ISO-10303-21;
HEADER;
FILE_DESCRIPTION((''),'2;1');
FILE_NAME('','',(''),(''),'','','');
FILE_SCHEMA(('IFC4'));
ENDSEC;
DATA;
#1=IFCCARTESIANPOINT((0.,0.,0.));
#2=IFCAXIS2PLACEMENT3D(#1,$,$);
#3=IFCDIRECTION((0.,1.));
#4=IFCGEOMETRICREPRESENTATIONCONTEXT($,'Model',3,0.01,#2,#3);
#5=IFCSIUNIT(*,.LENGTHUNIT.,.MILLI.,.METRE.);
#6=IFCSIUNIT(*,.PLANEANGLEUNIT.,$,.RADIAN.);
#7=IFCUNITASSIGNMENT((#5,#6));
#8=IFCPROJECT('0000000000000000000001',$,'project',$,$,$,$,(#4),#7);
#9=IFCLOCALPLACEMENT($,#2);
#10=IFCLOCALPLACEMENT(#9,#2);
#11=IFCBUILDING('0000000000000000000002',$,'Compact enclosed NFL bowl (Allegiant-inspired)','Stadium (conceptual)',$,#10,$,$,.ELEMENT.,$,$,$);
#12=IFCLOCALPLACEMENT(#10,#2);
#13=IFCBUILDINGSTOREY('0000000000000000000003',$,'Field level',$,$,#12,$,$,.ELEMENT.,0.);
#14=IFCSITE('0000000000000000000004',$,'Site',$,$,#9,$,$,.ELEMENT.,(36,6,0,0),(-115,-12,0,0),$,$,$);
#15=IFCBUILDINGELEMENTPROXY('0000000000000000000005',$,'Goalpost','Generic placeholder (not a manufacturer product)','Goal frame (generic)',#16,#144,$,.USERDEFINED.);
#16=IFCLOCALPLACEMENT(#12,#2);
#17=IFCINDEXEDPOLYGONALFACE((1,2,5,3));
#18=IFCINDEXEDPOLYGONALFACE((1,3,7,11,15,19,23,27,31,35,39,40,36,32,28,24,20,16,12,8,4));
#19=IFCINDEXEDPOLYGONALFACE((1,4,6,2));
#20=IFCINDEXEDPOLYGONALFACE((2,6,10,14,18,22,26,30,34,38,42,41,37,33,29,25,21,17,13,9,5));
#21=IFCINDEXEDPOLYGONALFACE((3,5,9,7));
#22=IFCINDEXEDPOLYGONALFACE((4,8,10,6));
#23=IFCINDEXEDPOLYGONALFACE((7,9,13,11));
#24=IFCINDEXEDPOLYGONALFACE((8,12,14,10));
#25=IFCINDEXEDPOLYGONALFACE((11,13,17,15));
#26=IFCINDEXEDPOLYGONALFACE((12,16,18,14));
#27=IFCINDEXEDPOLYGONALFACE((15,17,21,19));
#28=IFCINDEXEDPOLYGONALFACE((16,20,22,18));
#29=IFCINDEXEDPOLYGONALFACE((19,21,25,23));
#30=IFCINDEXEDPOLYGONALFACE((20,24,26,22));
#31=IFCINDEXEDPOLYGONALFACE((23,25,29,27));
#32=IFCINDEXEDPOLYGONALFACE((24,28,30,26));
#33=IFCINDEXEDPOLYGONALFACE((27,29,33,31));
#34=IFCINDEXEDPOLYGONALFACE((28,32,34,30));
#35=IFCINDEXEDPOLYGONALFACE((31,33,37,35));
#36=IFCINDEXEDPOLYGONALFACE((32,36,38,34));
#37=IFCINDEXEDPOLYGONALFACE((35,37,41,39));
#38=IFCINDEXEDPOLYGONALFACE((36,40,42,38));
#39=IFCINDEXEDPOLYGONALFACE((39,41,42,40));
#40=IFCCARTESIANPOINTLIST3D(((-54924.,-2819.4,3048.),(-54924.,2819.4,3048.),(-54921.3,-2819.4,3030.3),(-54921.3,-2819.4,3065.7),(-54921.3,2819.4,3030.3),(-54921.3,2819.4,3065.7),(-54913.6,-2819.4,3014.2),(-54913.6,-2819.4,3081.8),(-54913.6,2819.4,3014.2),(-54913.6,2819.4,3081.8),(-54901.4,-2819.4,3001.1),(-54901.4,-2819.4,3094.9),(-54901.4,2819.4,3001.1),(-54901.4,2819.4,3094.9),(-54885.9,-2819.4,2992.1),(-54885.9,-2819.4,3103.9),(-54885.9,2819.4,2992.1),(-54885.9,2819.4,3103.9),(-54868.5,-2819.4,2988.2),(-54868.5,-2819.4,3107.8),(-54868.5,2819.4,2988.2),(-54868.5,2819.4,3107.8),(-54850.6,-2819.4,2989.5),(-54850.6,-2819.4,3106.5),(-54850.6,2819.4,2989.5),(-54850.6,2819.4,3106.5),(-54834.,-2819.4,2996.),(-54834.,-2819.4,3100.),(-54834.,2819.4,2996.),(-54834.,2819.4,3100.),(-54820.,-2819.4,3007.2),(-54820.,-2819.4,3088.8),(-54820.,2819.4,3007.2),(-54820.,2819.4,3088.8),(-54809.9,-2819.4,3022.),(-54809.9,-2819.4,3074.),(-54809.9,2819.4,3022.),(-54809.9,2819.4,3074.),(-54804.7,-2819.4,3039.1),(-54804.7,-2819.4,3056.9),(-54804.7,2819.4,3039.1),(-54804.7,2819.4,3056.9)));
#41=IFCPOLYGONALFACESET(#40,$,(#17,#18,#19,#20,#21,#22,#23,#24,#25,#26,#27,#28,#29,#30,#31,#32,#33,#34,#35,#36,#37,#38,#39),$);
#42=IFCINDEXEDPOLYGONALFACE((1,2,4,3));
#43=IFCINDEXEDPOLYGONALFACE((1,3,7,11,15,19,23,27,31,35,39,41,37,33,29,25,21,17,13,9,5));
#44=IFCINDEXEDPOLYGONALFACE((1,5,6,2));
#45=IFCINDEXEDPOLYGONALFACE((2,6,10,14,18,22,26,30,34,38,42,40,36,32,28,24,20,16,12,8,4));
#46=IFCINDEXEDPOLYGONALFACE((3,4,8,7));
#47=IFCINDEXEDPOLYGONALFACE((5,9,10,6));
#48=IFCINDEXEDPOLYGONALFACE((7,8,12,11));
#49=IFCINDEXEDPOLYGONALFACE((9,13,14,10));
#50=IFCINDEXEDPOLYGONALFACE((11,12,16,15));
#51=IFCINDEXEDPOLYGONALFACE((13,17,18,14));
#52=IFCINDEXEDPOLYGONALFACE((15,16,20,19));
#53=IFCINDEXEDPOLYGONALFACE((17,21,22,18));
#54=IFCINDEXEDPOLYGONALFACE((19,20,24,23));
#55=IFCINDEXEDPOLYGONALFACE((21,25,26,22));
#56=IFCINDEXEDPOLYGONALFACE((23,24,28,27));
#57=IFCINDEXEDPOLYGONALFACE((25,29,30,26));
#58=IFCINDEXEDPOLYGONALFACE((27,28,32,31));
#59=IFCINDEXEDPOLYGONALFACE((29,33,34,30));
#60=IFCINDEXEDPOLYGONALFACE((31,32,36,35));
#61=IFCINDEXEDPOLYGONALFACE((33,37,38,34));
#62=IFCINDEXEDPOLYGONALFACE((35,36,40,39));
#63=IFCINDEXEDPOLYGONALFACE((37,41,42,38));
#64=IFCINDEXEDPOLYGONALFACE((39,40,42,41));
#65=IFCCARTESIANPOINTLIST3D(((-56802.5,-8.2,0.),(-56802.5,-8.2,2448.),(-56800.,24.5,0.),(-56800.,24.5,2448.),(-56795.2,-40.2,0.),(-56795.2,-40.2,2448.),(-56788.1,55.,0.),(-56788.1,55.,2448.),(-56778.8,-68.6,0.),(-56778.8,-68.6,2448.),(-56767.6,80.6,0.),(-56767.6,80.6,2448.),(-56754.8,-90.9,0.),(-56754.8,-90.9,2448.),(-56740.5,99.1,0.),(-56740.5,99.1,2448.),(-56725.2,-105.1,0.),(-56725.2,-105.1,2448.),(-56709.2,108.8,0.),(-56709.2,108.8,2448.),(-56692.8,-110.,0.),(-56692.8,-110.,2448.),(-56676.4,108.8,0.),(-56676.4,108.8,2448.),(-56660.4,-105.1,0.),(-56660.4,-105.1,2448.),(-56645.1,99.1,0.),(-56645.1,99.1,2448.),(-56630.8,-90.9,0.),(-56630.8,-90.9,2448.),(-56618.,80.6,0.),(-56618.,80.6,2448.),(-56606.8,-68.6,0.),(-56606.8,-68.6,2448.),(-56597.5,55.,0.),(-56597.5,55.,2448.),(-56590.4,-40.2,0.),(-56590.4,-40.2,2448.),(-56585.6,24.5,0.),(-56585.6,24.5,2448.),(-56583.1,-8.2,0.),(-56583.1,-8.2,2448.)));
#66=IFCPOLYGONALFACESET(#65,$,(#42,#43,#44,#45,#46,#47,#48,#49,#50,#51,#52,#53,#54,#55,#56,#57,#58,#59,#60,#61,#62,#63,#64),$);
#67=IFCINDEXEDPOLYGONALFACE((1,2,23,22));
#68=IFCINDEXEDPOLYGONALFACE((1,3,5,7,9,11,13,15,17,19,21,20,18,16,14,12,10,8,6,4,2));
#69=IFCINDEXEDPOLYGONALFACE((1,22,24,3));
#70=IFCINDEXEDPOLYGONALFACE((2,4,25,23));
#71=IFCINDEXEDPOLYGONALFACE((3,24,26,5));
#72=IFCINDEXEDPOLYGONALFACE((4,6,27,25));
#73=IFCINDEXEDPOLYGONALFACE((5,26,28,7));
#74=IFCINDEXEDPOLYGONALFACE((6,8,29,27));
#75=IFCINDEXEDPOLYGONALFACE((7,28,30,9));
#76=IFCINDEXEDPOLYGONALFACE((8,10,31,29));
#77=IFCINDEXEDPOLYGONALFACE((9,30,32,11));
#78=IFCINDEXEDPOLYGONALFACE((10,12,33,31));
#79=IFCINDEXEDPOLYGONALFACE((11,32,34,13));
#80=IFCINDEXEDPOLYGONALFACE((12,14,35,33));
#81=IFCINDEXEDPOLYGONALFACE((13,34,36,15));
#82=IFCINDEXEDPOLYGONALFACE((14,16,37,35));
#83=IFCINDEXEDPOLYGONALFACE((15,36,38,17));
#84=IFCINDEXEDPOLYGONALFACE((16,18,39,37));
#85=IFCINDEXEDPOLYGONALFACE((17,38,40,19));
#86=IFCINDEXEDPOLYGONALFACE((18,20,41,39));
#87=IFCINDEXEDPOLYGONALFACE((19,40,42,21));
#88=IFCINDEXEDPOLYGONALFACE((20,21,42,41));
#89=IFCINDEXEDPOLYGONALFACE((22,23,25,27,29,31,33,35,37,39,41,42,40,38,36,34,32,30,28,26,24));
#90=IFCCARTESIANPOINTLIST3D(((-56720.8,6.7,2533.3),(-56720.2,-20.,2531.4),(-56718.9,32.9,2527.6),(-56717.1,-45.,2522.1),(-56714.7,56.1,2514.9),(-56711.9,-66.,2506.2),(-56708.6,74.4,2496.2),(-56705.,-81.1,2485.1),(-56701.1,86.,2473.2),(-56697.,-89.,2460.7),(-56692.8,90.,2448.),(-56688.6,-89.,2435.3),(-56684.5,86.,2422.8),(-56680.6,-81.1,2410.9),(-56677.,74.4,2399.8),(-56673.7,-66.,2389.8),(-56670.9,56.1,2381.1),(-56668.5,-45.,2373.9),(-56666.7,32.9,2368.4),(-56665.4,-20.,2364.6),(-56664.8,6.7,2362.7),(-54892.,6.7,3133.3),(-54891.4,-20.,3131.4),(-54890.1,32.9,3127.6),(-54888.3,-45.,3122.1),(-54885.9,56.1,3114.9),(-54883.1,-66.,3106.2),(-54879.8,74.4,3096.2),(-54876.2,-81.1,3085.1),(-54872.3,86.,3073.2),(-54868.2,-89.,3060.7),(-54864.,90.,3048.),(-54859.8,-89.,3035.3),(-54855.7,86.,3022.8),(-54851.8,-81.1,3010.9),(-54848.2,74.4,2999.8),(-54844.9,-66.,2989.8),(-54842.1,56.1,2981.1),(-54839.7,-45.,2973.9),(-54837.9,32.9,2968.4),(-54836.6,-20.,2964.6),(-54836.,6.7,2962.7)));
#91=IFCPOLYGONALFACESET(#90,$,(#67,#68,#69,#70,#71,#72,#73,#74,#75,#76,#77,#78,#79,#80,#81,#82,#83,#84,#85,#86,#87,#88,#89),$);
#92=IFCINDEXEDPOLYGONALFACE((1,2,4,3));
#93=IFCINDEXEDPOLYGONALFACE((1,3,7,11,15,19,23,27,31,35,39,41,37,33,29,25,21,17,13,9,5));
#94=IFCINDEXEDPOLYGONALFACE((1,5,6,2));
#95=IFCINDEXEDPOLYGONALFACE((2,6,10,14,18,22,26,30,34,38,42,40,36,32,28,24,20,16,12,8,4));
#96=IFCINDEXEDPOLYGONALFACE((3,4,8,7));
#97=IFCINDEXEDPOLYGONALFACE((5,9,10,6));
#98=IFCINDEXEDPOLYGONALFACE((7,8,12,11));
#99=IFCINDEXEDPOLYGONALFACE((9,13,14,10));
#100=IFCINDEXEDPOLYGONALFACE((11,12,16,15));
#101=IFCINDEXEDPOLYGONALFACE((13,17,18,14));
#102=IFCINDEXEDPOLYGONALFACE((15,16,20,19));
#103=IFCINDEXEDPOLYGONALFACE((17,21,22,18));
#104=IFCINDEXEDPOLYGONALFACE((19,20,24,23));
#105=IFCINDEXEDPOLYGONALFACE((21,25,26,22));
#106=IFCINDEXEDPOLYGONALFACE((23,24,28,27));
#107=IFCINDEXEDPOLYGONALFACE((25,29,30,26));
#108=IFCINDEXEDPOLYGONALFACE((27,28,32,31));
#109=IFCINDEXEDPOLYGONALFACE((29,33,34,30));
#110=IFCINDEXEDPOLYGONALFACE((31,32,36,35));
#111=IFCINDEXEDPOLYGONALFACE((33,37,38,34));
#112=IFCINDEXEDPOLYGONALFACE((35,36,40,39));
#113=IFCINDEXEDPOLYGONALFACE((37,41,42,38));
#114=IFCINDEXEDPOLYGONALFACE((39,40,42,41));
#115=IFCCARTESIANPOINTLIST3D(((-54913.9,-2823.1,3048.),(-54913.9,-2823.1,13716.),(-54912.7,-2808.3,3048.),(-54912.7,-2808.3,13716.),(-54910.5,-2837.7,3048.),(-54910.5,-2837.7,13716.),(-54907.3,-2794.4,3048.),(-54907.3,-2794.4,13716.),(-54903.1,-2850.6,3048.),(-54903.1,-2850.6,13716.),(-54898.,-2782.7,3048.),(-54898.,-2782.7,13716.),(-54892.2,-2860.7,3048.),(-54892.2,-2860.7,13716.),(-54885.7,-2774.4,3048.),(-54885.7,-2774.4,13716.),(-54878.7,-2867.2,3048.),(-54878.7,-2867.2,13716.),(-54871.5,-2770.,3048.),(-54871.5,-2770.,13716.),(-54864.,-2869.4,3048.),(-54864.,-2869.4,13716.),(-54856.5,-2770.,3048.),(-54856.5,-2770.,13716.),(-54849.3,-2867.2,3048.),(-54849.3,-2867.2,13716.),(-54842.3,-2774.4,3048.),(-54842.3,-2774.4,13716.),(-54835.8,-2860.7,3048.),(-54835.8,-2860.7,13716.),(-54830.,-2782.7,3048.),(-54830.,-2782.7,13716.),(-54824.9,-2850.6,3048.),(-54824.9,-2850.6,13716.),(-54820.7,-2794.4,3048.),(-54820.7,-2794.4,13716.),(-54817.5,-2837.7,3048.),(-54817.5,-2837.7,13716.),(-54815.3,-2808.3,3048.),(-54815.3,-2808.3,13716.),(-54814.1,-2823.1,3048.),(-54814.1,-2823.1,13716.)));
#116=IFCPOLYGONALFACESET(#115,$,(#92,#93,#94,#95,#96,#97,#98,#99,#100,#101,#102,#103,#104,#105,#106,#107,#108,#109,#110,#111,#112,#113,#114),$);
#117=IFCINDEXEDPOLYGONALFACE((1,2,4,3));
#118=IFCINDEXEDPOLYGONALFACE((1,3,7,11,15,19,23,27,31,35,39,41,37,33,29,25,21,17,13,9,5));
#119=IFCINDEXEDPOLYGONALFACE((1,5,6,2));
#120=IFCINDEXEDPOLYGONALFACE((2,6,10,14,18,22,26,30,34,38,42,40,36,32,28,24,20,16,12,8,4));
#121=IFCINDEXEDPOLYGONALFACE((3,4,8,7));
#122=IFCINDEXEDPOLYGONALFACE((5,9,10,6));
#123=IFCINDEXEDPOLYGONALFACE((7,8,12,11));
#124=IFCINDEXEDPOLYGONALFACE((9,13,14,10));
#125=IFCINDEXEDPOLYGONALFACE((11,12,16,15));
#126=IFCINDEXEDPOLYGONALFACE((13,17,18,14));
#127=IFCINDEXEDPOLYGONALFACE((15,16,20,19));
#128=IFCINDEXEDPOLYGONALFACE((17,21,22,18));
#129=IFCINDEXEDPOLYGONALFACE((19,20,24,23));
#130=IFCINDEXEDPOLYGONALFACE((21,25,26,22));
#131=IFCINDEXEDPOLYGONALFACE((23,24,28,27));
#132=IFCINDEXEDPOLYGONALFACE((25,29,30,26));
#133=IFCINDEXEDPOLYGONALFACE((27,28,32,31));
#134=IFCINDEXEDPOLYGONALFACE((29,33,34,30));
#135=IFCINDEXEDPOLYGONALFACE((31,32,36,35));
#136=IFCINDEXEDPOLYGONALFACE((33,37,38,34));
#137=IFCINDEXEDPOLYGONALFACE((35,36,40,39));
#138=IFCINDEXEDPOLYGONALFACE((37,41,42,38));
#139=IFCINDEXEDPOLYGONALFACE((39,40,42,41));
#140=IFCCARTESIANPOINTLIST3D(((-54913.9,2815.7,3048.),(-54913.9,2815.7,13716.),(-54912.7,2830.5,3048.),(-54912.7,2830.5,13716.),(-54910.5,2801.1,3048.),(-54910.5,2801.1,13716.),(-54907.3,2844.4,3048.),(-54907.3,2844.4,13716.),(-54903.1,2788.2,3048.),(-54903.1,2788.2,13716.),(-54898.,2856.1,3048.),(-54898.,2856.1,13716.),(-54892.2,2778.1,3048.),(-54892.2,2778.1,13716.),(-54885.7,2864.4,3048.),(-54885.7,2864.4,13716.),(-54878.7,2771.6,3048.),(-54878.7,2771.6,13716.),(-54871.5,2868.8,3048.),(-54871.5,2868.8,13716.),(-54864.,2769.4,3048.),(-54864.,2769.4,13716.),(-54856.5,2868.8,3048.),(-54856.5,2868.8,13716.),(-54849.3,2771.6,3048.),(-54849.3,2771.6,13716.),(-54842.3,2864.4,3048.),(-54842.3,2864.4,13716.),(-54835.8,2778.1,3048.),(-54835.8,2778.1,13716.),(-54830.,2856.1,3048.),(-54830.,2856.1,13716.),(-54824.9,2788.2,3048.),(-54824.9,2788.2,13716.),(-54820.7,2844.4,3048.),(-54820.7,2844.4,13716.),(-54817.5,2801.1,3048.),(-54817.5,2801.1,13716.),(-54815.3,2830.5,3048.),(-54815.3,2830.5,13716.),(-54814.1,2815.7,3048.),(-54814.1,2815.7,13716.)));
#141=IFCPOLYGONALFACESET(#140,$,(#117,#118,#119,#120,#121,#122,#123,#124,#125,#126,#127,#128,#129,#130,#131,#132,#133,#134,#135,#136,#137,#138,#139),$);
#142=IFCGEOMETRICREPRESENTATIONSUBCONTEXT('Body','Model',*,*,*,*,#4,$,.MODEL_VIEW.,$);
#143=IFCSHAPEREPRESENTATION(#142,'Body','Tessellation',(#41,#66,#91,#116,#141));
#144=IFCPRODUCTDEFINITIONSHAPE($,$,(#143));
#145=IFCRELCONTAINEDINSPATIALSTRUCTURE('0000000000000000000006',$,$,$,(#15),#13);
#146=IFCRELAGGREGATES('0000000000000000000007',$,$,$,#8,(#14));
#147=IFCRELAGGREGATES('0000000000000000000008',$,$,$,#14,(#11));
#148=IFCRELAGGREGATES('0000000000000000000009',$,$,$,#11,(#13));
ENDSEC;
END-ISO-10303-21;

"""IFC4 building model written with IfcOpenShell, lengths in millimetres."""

from ifc_helpers import new_model, si_unit, direction, frame, origin, place, context, subcontext, project, spatial, circle, extrude, element, save


model = new_model("IFC4")

# Units and contexts
model_context = context("Model", 3, precision=0.01, world=origin(), true_north=direction((0.0, 1.0)))
body_context = subcontext(model_context, "Body", "Model", "MODEL_VIEW")
ifc_project = project(units=[si_unit("LENGTHUNIT", "METRE", prefix="MILLI"), si_unit("PLANEANGLEUNIT", "RADIAN")], contexts=[model_context])

# Site, building, storey
site_placement = place(None, origin())
site = spatial("IfcSite", under=ifc_project, at=site_placement, Name="Site", CompositionType="ELEMENT", RefLatitude=(36, 6, 0, 0), RefLongitude=(-115, -12, 0, 0))
building_placement = place(site_placement, origin())
building = spatial("IfcBuilding", under=site, at=building_placement, Name="Compact enclosed NFL bowl (Allegiant-inspired)", Description="Stadium (conceptual)", CompositionType="ELEMENT")
storey_placement = place(building_placement, origin())
storey = spatial("IfcBuildingStorey", under=building, at=storey_placement, Name="Field level", CompositionType="ELEMENT", Elevation=0.0)

# Shared definitions
placement = place(storey_placement, origin())

# Building element proxy
element("IfcBuildingElementProxy", 1, at=placement, inside=storey, Name="Goalpost", Description="Generic placeholder (not a manufacturer product)", ObjectType="Goal frame (generic)", PredefinedType="USERDEFINED", context=body_context, shape_type="SweptSolid", body=[
    extrude(circle(Radius=60.0), frame((-54864.0, -2819.4, 3048.0), z_axis=(0.0, 1.0, 0.0), x_axis=(-1.0, 0.0, 0.0)), (0.0, 0.0, 1.0), 5638.8),
    extrude(circle(Radius=110.0), frame((-56692.8, 0.0, 0.0), z_axis=(0.0, 0.0, 1.0), x_axis=(0.0, -1.0, 0.0)), (0.0, 0.0, 1.0), 2448.0),
    extrude(circle(Radius=90.0), frame((-56692.8, 0.0, 2448.0), z_axis=(0.950169, 0.0, 0.311735), x_axis=(0.0, 1.0, 0.0)), (0.0, 0.0, 1.0), 1924.7),
    extrude(circle(Radius=50.0), frame((-54864.0, -2819.4, 3048.0), z_axis=(0.0, 0.0, 1.0), x_axis=(0.0, -1.0, 0.0)), (0.0, 0.0, 1.0), 10668.0),
    extrude(circle(Radius=50.0), frame((-54864.0, 2819.4, 3048.0), z_axis=(0.0, 0.0, 1.0), x_axis=(0.0, -1.0, 0.0)), (0.0, 0.0, 1.0), 10668.0),
])

save(model, "model.ifc")
